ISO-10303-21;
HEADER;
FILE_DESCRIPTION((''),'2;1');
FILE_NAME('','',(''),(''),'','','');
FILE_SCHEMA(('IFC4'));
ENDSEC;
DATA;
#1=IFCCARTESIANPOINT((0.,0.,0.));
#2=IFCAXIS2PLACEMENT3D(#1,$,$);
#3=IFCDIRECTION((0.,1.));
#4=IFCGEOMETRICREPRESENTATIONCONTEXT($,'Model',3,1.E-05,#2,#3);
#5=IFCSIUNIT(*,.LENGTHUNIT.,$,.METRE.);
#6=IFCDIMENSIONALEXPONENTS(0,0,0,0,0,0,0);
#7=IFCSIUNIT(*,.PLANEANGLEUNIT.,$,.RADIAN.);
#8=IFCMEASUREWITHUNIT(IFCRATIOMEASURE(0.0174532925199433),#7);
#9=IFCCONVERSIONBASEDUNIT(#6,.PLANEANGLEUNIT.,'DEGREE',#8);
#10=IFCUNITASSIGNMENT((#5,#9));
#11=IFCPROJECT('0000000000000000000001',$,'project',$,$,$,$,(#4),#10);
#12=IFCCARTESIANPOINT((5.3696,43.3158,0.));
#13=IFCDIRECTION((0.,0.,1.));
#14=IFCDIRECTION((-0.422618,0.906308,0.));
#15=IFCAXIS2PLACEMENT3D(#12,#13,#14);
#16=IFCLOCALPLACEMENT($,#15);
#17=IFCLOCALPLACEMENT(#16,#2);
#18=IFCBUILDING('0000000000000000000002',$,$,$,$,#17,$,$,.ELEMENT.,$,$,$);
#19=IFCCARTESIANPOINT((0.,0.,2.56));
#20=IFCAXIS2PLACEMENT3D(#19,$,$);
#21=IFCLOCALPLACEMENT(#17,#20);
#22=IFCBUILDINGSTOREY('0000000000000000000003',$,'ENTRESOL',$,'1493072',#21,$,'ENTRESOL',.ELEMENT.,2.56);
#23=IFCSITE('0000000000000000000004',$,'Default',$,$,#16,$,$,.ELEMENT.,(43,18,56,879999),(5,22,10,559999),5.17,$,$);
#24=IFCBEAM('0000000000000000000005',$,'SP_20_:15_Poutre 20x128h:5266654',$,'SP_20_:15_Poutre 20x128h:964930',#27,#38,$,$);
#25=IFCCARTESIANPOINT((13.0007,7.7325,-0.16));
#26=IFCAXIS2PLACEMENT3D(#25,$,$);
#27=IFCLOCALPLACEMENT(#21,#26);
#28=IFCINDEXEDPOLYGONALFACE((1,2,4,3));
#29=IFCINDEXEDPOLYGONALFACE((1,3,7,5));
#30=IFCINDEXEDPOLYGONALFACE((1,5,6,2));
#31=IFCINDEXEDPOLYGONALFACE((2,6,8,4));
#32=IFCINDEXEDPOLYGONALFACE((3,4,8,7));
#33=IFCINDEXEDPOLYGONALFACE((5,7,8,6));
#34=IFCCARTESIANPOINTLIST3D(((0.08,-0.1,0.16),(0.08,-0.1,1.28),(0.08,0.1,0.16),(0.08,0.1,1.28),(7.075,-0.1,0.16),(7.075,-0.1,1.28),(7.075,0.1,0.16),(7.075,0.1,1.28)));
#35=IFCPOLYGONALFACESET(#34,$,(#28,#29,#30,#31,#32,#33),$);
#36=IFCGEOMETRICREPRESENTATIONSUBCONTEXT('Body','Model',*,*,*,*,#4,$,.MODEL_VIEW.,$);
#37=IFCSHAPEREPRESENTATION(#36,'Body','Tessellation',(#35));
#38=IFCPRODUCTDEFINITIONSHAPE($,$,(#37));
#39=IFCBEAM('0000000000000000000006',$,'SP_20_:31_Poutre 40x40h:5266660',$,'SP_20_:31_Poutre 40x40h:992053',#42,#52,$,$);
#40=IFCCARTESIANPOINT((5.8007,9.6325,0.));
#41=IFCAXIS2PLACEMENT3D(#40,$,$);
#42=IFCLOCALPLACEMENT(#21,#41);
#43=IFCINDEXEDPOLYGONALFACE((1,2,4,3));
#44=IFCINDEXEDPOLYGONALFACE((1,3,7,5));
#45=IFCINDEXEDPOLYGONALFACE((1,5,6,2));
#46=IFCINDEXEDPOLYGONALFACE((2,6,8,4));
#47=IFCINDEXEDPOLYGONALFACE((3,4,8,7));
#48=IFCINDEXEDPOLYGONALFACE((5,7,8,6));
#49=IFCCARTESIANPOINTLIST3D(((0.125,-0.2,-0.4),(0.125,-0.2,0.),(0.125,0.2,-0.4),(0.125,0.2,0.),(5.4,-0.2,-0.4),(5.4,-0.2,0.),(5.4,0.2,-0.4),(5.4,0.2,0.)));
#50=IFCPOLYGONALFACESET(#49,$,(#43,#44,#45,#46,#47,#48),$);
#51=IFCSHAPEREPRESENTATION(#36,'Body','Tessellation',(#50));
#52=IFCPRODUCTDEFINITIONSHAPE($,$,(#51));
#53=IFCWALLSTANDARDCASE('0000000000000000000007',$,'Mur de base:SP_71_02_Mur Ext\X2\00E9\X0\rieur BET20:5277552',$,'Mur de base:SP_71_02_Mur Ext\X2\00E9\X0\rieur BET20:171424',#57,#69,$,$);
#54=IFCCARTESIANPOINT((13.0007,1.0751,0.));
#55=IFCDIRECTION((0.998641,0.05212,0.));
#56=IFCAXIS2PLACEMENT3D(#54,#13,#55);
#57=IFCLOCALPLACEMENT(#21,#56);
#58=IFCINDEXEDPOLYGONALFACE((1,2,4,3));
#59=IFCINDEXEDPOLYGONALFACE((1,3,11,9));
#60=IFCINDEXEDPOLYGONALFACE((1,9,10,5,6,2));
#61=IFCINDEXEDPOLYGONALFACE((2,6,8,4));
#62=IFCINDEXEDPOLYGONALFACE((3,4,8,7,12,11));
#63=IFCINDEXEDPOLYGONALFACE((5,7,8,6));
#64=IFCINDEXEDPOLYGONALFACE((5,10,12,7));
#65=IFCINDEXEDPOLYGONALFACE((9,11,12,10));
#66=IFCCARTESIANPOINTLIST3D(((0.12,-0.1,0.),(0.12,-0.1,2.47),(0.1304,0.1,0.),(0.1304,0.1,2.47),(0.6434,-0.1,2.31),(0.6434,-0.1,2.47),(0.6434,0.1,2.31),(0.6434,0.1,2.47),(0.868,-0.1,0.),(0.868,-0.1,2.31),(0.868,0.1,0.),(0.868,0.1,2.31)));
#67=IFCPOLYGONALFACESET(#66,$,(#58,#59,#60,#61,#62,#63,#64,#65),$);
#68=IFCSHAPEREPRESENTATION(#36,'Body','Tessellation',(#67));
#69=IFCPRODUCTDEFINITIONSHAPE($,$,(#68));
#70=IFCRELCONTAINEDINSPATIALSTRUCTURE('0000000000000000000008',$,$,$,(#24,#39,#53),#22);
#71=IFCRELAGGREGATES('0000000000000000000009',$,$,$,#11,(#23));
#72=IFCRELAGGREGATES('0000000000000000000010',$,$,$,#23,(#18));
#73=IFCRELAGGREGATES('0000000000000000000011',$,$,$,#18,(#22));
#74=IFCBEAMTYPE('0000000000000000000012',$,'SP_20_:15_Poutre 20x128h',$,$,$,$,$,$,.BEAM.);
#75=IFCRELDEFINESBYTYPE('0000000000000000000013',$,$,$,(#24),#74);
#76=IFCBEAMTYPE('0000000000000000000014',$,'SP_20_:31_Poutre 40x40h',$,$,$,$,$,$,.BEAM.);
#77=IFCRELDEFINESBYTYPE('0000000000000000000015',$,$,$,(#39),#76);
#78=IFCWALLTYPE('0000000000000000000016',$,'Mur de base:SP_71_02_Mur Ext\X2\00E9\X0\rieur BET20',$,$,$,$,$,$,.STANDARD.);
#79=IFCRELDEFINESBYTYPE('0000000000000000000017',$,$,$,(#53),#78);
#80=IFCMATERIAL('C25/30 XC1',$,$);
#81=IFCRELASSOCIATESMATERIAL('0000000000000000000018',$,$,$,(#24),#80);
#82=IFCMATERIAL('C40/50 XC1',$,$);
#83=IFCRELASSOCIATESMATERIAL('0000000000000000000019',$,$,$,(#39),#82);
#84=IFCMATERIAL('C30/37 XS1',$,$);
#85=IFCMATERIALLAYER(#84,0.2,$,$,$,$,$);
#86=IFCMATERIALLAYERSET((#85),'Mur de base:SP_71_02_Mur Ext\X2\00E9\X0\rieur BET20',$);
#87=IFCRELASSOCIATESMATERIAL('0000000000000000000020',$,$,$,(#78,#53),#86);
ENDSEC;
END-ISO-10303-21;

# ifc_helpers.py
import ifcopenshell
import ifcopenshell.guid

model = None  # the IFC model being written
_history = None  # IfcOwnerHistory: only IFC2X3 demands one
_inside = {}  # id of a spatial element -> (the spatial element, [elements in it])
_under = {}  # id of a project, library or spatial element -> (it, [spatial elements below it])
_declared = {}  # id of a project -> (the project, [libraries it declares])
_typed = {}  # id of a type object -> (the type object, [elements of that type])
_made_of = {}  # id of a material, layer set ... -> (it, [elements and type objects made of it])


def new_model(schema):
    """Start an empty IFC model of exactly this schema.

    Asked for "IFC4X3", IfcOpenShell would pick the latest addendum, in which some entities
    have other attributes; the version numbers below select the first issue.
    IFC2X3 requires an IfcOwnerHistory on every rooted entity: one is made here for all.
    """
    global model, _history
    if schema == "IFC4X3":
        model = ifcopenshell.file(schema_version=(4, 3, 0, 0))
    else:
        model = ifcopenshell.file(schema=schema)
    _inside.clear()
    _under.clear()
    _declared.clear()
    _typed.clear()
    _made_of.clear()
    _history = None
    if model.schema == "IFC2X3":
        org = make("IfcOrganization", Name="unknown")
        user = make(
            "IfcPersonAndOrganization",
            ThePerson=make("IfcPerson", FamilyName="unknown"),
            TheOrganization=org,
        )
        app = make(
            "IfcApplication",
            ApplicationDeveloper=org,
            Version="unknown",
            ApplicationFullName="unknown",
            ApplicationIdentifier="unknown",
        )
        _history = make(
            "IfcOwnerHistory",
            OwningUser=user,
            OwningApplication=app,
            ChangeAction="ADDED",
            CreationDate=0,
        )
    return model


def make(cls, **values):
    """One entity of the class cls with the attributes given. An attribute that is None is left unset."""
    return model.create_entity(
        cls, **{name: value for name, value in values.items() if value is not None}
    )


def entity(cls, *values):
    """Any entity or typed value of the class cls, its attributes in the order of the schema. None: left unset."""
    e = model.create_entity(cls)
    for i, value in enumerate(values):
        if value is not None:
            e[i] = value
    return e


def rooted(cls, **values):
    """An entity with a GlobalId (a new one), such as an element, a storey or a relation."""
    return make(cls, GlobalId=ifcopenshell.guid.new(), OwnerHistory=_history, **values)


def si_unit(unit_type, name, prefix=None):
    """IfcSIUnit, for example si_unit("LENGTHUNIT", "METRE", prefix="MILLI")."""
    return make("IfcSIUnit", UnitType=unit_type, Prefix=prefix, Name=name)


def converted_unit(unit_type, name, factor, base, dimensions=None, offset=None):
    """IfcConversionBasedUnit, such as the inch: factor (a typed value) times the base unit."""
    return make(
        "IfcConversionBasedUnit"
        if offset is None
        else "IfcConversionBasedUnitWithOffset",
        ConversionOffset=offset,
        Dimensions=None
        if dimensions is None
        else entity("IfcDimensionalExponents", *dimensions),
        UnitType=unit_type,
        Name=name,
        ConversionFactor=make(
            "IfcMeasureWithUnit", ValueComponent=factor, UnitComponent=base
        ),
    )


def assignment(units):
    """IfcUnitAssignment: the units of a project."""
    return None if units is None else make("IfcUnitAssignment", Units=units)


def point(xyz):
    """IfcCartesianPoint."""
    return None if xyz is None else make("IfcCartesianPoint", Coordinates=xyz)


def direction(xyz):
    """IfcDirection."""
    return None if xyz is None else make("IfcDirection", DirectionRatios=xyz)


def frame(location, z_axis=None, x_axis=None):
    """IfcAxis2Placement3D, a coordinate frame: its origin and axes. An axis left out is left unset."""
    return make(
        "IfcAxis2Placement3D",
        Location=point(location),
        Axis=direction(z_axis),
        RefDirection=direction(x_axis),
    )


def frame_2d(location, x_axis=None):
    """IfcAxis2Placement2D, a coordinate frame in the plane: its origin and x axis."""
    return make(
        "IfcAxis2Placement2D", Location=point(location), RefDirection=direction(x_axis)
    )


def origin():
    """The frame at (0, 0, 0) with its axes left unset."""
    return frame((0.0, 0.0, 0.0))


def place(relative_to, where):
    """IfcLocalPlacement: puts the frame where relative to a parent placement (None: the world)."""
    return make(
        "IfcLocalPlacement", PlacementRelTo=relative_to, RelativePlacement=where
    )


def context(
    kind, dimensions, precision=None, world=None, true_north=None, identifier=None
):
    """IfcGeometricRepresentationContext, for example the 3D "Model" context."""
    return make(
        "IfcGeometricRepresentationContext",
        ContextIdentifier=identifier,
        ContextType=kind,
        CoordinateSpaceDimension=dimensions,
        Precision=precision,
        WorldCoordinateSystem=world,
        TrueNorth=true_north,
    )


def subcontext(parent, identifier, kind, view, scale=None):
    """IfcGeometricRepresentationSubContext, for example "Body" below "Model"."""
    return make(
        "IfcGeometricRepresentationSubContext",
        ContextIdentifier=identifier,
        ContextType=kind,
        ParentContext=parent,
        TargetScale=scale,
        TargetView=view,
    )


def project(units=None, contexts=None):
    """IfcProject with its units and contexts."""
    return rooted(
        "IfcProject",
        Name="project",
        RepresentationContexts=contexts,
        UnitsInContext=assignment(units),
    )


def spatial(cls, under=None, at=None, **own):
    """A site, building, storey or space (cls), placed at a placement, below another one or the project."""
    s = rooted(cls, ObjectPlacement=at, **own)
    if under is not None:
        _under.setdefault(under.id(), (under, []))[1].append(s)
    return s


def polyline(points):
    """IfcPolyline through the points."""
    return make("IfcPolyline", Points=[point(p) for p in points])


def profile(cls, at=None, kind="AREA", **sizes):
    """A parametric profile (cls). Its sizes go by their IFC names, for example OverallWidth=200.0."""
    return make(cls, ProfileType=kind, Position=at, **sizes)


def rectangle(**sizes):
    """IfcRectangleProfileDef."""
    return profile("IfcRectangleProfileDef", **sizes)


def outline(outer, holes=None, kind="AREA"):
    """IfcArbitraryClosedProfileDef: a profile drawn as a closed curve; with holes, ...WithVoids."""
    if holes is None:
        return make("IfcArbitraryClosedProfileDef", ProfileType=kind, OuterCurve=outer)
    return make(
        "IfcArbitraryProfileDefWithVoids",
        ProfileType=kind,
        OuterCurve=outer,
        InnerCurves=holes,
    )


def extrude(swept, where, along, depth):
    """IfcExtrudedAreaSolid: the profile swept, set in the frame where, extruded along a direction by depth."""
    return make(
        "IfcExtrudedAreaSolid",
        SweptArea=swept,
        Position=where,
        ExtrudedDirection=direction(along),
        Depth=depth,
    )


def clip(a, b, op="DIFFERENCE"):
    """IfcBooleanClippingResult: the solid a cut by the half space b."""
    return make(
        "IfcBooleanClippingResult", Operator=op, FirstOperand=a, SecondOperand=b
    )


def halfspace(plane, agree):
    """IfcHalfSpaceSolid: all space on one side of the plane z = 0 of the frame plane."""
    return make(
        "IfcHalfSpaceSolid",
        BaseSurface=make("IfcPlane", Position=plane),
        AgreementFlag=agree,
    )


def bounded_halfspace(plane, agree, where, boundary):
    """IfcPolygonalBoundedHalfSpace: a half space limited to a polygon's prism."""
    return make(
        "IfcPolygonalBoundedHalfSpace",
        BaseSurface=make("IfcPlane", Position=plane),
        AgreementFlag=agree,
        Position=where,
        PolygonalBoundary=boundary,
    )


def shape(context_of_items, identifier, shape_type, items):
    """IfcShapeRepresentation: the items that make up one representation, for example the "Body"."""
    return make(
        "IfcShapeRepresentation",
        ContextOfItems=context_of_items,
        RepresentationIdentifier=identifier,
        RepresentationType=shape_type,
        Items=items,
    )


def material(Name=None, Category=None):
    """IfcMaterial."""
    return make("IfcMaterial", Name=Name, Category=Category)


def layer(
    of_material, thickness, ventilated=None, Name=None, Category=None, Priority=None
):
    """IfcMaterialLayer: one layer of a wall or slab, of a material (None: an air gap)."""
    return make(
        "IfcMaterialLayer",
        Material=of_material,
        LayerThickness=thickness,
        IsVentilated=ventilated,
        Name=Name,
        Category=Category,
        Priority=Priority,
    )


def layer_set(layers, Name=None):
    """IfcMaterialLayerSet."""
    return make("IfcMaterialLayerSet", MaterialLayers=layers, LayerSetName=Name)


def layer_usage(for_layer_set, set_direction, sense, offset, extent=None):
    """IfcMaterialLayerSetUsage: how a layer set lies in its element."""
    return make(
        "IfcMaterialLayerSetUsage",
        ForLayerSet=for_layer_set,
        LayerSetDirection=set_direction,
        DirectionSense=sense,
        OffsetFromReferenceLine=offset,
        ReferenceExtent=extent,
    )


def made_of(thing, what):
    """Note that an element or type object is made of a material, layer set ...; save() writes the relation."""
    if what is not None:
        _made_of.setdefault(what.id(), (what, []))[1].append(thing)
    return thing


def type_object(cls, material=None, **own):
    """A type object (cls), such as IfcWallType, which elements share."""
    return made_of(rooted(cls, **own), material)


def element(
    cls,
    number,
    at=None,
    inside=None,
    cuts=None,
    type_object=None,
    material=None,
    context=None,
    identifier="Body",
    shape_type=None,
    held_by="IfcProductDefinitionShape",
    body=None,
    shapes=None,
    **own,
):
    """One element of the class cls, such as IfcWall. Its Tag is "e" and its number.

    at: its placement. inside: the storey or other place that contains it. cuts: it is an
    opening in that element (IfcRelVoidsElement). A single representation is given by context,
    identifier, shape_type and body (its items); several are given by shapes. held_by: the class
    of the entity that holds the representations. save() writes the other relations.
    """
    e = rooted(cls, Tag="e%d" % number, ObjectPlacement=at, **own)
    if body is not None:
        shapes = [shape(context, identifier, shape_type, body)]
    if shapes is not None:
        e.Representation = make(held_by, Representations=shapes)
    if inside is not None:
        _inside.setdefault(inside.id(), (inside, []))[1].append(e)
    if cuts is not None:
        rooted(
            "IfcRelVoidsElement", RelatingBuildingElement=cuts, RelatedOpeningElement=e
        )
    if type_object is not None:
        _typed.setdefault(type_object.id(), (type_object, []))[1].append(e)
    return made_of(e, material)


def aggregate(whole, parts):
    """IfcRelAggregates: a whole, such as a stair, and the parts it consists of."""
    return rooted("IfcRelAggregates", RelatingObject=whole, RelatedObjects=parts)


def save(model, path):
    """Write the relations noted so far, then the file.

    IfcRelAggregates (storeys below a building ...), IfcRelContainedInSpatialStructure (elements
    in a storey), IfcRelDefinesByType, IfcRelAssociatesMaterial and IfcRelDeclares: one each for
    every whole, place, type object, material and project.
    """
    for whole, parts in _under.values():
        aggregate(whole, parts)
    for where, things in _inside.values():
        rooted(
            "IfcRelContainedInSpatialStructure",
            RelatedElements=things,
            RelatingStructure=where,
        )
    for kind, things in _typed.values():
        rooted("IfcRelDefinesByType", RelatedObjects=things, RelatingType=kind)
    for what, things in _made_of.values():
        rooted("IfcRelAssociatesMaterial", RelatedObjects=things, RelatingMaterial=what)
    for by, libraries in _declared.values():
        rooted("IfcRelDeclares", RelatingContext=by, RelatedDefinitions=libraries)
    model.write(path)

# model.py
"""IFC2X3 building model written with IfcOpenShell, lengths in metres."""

from ifc_helpers import new_model, entity, si_unit, converted_unit, direction, frame, frame_2d, origin, place, context, subcontext, project, spatial, polyline, rectangle, outline, extrude, clip, halfspace, bounded_halfspace, material, layer, layer_set, layer_usage, type_object, element, save


model = new_model("IFC2X3")

# Units and contexts
model_context = context("Model", 3, precision=1e-05, world=origin(), true_north=direction((0.0, 1.0)))
body_context = subcontext(model_context, "Body", "Model", "MODEL_VIEW")
ifc_project = project(units=[si_unit("LENGTHUNIT", "METRE"), converted_unit("PLANEANGLEUNIT", "DEGREE", entity("IfcRatioMeasure", 0.0174532925199433), si_unit("PLANEANGLEUNIT", "RADIAN"), dimensions=[0, 0, 0, 0, 0, 0, 0])], contexts=[model_context])

# Site, building, storey
site_placement = place(None, frame((5.3696, 43.3158, 0.0), z_axis=(0.0, 0.0, 1.0), x_axis=(-0.422618, 0.906308, 0.0)))
site = spatial("IfcSite", under=ifc_project, at=site_placement, Name="Default", CompositionType="ELEMENT", RefLatitude=(43, 18, 56, 879999), RefLongitude=(5, 22, 10, 559999), RefElevation=5.17)
building_placement = place(site_placement, origin())
building = spatial("IfcBuilding", under=site, at=building_placement, CompositionType="ELEMENT")
storey_placement = place(building_placement, frame((0.0, 0.0, 2.56)))
storey = spatial("IfcBuildingStorey", under=building, at=storey_placement, Name="ENTRESOL", ObjectType="1493072", LongName="ENTRESOL", CompositionType="ELEMENT", Elevation=2.56)

# Beams
ifc_material_1 = material(Name="C25/30 XC1")
beam_type_1 = type_object("IfcBeamType", Name="SP_20_:15_Poutre 20x128h", PredefinedType="BEAM")
beam_1_placement = place(storey_placement, frame((13.0007, 7.7325, -0.16)))
element("IfcBeam", 1, at=beam_1_placement, inside=storey, type_object=beam_type_1, material=ifc_material_1, Name="SP_20_:15_Poutre 20x128h:5266654", ObjectType="SP_20_:15_Poutre 20x128h:964930", context=body_context, shape_type="SweptSolid", body=[
    extrude(rectangle(XDim=1.12, YDim=0.2, at=frame_2d((0.0, 0.0), x_axis=(1.0, 0.0))), frame((0.08, 0.0, 0.72), z_axis=(1.0, 0.0, 0.0), x_axis=(0.0, 0.0, -1.0)), (0.0, 0.0, 1.0), 6.995),
])
ifc_material_2 = material(Name="C40/50 XC1")
beam_type_2 = type_object("IfcBeamType", Name="SP_20_:31_Poutre 40x40h", PredefinedType="BEAM")
beam_2_placement = place(storey_placement, frame((5.8007, 9.6325, 0.0)))
element("IfcBeam", 2, at=beam_2_placement, inside=storey, type_object=beam_type_2, material=ifc_material_2, Name="SP_20_:31_Poutre 40x40h:5266660", ObjectType="SP_20_:31_Poutre 40x40h:992053", context=body_context, shape_type="SweptSolid", body=[
    extrude(rectangle(XDim=0.4, YDim=0.4, at=frame_2d((0.0, 0.0), x_axis=(1.0, 0.0))), frame((0.125, 0.0, -0.2), z_axis=(1.0, 0.0, 0.0), x_axis=(0.0, 0.0, -1.0)), (0.0, 0.0, 1.0), 5.275),
])

# Shared definitions
ifc_material_3 = material(Name="C30/37 XS1")

# Shared definitions
ifc_layer_1 = layer(ifc_material_3, 0.2)
ifc_layer_set_1 = layer_set([ifc_layer_1], Name="Mur de base:SP_71_02_Mur Extérieur BET20")
wall_type_1 = type_object("IfcWallType", Name="Mur de base:SP_71_02_Mur Extérieur BET20", PredefinedType="STANDARD", material=ifc_layer_set_1)

# Wall
ifc_layer_usage_1 = layer_usage(ifc_layer_set_1, "AXIS2", "NEGATIVE", 0.1)
wall_1_placement = place(storey_placement, frame((13.0007, 1.0751, 0.0), z_axis=(0.0, 0.0, 1.0), x_axis=(0.998641, 0.05212, 0.0)))
element("IfcWallStandardCase", 3, at=wall_1_placement, inside=storey, type_object=wall_type_1, material=ifc_layer_usage_1, Name="Mur de base:SP_71_02_Mur Extérieur BET20:5277552", ObjectType="Mur de base:SP_71_02_Mur Extérieur BET20:171424", context=body_context, shape_type="Clipping", body=[
    clip(clip(clip(extrude(outline(polyline([(0.868, -0.1), (0.868, 0.1), (0.1304, 0.1), (0.12, -0.1), (0.868, -0.1)])), origin(), (0.0, 0.0, 1.0), 2.47), bounded_halfspace(frame((0.6434, 0.1, 2.31), z_axis=(0.0, 0.0, -1.0), x_axis=(1.0, 0.0, 0.0)), True, frame((0.6434, 0.1, 2.31), z_axis=(0.0, 0.0, -1.0), x_axis=(1.0, 0.0, 0.0)), polyline([(0.0, 0.0), (0.2246, 0.0), (0.2246, 0.2), (0.0, 0.2), (0.0, 0.0)]))), bounded_halfspace(frame((0.6434, -0.1, 2.31), z_axis=(-1.0, 0.0, 0.0), x_axis=(0.0, 0.0, 1.0)), True, frame((0.6434, -0.1, 2.31), z_axis=(-1.0, 0.0, 0.0), x_axis=(0.0, 0.0, 1.0)), polyline([(0.0, 0.0), (0.16, 0.0), (0.16, 0.2), (0.0, 0.2), (0.0, 0.0)]))), halfspace(frame((0.0, 0.0, -2.56)), True)),
])

save(model, "model.ifc")
